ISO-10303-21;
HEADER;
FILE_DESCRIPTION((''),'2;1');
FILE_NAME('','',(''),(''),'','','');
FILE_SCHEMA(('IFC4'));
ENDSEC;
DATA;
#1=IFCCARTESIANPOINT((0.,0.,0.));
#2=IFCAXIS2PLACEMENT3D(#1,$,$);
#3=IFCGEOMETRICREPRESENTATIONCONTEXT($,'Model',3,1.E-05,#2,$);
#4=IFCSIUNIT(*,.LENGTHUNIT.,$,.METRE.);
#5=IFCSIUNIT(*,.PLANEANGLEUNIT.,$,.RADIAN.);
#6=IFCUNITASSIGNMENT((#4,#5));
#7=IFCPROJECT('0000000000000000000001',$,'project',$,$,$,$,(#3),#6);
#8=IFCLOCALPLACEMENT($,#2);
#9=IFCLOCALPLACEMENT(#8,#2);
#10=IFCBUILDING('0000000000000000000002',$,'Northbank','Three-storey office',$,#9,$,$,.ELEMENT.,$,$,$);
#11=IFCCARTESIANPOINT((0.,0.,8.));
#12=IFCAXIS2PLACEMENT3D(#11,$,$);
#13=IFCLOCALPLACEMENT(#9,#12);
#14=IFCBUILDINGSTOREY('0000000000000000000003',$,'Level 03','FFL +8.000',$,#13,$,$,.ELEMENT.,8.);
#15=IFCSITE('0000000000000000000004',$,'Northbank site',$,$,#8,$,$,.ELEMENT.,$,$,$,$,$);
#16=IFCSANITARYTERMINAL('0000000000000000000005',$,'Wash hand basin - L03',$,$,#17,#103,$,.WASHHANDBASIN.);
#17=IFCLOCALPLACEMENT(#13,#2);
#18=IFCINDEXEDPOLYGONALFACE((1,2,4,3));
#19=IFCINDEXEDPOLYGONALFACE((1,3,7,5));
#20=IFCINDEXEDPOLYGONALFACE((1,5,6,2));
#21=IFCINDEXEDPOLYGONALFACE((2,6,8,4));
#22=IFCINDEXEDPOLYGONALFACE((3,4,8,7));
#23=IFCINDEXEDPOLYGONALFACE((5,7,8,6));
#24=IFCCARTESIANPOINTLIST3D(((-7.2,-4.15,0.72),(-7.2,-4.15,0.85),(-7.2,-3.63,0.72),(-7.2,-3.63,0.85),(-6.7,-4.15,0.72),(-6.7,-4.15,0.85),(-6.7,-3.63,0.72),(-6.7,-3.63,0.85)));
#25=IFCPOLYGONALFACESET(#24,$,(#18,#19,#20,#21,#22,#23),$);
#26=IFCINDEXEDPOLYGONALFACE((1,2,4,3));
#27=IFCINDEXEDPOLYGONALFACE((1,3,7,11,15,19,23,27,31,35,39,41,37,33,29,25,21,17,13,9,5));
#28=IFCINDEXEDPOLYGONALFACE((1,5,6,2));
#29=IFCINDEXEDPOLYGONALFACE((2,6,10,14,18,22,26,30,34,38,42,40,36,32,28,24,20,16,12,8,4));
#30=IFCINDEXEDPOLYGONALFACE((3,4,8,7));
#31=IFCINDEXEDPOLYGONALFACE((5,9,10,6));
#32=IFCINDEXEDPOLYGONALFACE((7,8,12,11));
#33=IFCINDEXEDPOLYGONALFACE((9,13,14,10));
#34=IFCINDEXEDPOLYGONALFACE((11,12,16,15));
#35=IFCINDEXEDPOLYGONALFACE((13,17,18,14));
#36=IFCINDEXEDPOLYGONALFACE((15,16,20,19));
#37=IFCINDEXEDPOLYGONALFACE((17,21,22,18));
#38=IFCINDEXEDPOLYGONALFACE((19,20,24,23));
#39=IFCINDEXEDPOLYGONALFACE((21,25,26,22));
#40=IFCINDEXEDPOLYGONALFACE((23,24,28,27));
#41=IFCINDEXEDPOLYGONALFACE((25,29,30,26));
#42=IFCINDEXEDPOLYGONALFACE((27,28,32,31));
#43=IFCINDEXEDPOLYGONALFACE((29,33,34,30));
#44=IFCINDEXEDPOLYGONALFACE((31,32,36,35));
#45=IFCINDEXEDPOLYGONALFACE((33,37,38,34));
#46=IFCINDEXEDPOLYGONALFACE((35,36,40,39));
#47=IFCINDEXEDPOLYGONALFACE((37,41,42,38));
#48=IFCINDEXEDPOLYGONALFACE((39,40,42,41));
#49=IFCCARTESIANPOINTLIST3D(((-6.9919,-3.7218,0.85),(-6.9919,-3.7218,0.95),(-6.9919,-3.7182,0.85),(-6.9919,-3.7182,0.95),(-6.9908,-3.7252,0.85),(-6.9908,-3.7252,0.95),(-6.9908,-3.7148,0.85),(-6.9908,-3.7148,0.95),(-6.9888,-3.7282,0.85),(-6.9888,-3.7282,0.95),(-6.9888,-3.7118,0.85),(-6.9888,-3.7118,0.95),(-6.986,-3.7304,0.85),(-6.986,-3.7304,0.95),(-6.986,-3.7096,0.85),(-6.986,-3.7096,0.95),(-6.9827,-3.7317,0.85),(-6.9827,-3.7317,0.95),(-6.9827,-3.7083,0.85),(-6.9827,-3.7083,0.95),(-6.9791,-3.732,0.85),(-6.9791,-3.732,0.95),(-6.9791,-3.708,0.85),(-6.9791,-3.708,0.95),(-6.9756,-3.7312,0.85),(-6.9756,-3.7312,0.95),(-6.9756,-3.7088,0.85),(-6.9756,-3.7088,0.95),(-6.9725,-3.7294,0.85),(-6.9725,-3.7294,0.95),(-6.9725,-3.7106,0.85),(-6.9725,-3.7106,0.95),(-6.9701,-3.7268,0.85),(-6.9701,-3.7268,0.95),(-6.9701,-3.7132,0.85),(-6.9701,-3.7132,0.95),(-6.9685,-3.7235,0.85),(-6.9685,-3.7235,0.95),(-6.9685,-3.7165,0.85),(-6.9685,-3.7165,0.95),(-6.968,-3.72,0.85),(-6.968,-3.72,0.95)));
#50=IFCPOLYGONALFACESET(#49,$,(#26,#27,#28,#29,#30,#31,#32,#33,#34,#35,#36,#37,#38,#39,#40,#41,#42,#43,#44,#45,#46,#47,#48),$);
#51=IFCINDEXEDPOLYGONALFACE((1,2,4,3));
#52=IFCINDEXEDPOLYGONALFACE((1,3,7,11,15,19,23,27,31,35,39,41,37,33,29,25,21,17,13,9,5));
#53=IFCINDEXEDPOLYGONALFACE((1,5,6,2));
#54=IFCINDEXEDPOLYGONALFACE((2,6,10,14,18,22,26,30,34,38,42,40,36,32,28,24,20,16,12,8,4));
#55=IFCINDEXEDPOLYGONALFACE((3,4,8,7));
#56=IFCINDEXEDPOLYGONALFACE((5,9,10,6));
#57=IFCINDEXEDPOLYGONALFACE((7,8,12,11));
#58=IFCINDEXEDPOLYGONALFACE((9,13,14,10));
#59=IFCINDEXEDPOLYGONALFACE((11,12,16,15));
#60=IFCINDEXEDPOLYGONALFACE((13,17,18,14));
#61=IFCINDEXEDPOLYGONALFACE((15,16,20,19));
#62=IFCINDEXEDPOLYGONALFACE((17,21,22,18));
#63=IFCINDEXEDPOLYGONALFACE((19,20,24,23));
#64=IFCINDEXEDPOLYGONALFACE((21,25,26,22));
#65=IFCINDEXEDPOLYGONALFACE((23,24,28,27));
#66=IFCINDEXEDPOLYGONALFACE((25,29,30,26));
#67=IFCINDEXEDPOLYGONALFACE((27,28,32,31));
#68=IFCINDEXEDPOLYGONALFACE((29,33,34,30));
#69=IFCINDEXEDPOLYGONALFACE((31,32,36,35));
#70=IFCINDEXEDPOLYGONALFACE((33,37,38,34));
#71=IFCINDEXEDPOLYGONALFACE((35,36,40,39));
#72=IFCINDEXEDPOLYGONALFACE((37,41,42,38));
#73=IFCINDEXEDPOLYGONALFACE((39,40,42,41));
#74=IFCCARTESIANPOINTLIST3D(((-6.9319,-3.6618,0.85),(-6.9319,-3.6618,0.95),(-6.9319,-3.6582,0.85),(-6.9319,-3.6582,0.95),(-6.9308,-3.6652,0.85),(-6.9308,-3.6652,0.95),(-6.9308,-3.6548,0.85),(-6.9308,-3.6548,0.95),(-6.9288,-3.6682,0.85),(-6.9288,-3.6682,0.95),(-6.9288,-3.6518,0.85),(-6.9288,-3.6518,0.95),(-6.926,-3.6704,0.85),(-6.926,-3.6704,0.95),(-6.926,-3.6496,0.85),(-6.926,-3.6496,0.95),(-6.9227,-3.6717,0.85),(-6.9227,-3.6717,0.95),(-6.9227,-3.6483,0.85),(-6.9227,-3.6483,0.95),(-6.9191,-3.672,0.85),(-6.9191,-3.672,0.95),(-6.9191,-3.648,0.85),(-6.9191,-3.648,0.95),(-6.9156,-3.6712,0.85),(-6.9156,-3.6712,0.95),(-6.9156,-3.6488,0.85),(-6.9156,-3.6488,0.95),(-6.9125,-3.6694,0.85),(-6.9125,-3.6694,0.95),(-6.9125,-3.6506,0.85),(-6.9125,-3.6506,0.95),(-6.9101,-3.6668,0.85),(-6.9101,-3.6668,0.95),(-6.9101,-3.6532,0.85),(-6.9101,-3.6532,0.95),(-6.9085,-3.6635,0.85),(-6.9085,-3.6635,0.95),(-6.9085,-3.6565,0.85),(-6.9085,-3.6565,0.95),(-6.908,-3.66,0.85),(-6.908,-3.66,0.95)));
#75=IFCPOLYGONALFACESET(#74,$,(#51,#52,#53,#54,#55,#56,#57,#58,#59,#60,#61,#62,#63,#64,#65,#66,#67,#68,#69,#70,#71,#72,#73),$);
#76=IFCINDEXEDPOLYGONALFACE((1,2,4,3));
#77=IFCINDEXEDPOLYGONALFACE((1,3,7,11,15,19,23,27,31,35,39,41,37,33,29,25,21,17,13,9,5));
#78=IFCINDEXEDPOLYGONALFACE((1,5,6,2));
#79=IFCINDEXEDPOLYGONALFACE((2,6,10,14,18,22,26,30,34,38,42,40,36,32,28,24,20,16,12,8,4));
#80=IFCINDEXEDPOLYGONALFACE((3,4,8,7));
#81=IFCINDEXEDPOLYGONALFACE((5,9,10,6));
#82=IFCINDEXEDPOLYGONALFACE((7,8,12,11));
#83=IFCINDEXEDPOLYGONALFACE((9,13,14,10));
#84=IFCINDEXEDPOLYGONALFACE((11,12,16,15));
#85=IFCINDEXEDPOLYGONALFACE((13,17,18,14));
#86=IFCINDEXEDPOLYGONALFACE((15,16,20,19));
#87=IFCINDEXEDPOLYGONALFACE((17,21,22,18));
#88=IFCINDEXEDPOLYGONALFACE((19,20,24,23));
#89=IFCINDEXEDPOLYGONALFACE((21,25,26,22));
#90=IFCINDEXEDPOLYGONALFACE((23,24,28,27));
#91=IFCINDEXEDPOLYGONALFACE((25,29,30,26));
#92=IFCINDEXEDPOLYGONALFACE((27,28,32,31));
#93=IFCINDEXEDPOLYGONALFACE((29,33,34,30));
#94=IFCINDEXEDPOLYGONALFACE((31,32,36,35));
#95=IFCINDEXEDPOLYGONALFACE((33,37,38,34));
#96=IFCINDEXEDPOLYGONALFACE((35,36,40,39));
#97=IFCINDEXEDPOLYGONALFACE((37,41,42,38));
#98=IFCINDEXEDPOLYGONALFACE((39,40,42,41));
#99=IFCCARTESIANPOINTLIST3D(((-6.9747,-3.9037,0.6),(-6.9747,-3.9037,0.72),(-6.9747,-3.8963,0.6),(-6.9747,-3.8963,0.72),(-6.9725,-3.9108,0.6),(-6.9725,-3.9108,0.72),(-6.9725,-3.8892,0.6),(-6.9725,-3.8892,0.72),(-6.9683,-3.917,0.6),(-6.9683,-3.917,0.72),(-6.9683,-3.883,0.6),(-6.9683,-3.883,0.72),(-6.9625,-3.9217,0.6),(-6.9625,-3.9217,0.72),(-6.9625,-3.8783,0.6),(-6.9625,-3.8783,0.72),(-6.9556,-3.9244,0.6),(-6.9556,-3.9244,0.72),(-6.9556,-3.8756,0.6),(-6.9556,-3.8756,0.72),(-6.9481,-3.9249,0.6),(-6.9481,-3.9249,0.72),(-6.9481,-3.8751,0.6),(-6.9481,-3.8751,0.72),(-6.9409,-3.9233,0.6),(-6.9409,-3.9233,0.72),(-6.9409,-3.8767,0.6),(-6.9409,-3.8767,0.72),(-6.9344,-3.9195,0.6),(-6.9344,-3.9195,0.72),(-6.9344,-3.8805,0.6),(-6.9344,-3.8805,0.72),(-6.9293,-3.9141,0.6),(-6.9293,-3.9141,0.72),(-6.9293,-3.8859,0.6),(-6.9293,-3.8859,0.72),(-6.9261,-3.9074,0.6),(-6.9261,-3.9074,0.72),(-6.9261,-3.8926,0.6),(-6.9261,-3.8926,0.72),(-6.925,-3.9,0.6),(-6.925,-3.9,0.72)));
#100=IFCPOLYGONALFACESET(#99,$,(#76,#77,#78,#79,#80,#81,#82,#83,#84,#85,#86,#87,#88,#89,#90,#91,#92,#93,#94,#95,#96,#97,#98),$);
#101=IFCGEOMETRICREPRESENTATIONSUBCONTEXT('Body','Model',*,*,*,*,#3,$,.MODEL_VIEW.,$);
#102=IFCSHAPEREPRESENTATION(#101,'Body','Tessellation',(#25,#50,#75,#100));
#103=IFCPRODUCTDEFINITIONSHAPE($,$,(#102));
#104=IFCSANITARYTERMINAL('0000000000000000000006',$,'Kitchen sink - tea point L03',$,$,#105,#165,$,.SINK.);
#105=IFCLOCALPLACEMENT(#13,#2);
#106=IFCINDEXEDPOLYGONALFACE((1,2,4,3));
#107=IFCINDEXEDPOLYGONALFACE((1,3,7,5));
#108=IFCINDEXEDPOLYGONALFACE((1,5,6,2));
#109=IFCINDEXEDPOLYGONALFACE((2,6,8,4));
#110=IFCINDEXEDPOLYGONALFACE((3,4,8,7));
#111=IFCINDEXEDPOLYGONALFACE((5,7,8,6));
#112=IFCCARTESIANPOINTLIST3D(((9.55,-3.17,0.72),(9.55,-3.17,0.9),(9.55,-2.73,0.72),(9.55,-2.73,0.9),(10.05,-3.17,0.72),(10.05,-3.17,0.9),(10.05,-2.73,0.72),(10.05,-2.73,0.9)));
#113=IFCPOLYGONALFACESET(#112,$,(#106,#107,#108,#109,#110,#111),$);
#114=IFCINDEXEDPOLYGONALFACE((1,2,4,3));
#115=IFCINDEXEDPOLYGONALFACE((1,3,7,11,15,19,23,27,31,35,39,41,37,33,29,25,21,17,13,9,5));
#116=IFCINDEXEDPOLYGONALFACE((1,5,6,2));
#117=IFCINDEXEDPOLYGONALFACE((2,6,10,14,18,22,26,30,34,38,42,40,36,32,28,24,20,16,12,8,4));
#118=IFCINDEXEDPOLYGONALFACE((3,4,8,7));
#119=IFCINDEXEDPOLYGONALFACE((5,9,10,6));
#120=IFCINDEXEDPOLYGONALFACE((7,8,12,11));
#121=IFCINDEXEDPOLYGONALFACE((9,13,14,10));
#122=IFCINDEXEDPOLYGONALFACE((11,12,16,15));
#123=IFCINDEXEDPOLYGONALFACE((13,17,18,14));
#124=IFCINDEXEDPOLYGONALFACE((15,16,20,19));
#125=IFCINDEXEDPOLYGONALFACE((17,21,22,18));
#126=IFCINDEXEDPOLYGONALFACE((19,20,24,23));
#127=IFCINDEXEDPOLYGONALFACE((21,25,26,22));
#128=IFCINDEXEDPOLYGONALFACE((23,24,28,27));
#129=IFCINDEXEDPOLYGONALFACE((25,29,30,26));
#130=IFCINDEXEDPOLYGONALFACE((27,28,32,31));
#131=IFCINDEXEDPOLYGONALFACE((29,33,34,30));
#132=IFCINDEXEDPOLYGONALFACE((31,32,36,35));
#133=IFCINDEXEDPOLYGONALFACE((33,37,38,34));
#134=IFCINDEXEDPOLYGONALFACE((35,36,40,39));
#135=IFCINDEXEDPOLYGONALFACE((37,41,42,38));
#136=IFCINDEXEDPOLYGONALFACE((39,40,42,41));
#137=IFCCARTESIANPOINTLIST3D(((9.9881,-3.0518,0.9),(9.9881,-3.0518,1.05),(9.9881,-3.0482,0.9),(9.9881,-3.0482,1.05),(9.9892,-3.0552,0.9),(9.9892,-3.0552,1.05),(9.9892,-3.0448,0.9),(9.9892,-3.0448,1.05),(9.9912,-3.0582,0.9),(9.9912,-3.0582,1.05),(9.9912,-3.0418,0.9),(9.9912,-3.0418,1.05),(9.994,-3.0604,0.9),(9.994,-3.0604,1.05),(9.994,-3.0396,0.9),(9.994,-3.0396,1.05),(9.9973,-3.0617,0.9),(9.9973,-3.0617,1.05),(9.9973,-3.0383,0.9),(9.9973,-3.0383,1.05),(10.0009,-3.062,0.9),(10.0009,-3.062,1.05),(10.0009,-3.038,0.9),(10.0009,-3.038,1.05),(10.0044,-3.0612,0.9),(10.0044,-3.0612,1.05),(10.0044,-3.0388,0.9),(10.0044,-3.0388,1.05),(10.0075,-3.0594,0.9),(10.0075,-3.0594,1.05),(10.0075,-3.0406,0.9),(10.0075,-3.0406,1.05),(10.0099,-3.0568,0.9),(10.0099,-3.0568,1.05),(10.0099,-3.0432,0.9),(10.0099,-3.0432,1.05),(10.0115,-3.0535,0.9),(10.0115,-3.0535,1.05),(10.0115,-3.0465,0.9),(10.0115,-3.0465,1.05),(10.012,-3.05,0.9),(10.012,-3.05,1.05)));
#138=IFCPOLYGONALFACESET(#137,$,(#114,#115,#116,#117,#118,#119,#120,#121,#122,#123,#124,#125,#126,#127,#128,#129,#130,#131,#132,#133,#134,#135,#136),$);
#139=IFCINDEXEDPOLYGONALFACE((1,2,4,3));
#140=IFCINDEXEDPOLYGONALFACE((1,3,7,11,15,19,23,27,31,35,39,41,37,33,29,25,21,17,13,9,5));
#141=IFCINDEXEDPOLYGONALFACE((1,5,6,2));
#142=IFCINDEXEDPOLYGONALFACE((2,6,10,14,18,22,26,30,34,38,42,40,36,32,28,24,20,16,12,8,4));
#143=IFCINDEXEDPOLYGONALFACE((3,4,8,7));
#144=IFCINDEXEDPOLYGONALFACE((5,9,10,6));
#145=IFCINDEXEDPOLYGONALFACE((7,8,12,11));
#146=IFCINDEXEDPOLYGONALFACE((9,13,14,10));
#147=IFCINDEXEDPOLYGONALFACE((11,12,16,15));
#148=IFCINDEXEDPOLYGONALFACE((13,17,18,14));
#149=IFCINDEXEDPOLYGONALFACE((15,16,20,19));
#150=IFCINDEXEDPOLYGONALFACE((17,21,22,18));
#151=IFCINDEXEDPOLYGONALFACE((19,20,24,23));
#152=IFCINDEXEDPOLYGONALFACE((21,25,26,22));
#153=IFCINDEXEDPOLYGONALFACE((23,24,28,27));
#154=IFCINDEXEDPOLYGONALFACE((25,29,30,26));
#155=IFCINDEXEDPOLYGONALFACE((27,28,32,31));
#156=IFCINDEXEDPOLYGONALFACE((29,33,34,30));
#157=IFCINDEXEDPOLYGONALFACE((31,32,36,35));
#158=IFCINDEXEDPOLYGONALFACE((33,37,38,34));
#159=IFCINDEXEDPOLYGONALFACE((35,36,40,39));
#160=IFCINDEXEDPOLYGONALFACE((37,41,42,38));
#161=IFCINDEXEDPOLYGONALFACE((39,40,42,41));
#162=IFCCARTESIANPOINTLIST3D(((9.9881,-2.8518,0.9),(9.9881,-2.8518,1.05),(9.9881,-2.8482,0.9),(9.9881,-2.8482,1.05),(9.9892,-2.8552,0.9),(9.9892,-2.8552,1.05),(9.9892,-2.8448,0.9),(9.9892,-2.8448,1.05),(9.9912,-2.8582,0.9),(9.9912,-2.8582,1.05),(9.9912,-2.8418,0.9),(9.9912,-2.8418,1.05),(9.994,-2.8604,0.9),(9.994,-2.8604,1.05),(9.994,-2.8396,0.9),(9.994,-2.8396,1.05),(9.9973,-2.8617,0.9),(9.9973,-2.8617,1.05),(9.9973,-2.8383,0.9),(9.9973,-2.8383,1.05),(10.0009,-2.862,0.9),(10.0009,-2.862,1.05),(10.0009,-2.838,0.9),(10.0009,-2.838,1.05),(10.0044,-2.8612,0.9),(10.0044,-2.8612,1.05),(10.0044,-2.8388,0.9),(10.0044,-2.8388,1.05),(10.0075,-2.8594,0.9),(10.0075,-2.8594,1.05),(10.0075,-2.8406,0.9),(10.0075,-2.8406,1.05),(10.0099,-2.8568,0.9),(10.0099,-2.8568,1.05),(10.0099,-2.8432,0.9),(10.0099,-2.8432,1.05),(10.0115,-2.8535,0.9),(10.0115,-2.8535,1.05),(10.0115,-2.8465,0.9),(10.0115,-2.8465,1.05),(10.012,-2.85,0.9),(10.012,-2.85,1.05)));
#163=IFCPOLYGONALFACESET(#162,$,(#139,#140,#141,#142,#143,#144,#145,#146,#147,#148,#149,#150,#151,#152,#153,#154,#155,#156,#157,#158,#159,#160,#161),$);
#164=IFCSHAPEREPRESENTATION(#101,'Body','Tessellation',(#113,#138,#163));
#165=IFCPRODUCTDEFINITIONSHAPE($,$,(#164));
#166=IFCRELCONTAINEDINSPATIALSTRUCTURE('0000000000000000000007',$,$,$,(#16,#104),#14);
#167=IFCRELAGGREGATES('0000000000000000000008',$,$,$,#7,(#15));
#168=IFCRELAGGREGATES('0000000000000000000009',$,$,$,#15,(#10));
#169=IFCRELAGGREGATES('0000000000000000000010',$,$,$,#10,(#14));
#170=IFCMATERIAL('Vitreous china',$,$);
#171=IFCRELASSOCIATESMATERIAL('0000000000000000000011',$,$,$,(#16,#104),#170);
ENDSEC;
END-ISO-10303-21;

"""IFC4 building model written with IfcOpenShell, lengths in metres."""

from ifc_helpers import new_model, si_unit, frame, origin, place, context, subcontext, project, spatial, rectangle, circle, extrude, material, element, save


model = new_model("IFC4")

# Units and contexts
model_context = context("Model", 3, precision=1e-05, world=origin())
body_context = subcontext(model_context, "Body", "Model", "MODEL_VIEW")
ifc_project = project(units=[si_unit("LENGTHUNIT", "METRE"), si_unit("PLANEANGLEUNIT", "RADIAN")], contexts=[model_context])

# Site, building, storey
site_placement = place(None, origin())
site = spatial("IfcSite", under=ifc_project, at=site_placement, Name="Northbank site", CompositionType="ELEMENT")
building_placement = place(site_placement, origin())
building = spatial("IfcBuilding", under=site, at=building_placement, Name="Northbank", Description="Three-storey office", CompositionType="ELEMENT")
storey_placement = place(building_placement, frame((0.0, 0.0, 8.0)))
storey = spatial("IfcBuildingStorey", under=building, at=storey_placement, Name="Level 03", Description="FFL +8.000", CompositionType="ELEMENT", Elevation=8.0)

# Sanitary terminals
ifc_material_1 = material(Name="Vitreous china")
sanitary_terminal_1_placement = place(storey_placement, frame((0.0, 0.0, -8.0)))
element("IfcSanitaryTerminal", 1, at=sanitary_terminal_1_placement, inside=storey, material=ifc_material_1, Name="Wash hand basin - L03", PredefinedType="WASHHANDBASIN", context=body_context, shape_type="SweptSolid", body=[
    extrude(rectangle(XDim=0.5, YDim=0.52), frame((-6.95, -3.89, 8.72)), (0.0, 0.0, 1.0), 0.13),
    extrude(circle(Radius=0.012), frame((-6.98, -3.72, 8.85), z_axis=(0.0, 0.0, 1.0), x_axis=(1.0, 0.0, 0.0)), (0.0, 0.0, 1.0), 0.1),
    extrude(circle(Radius=0.012), frame((-6.92, -3.66, 8.85), z_axis=(0.0, 0.0, 1.0), x_axis=(1.0, 0.0, 0.0)), (0.0, 0.0, 1.0), 0.1),
    extrude(circle(Radius=0.025), frame((-6.95, -3.9, 8.72), z_axis=(0.0, 0.0, -1.0), x_axis=(1.0, 0.0, 0.0)), (0.0, 0.0, 1.0), 0.12),
])
sanitary_terminal_2_placement = place(storey_placement, frame((0.0, 0.0, -8.0)))
element("IfcSanitaryTerminal", 2, at=sanitary_terminal_2_placement, inside=storey, material=ifc_material_1, Name="Kitchen sink - tea point L03", PredefinedType="SINK", context=body_context, shape_type="SweptSolid", body=[
    extrude(rectangle(XDim=0.5, YDim=0.44), frame((9.8, -2.95, 8.72)), (0.0, 0.0, 1.0), 0.18),
    extrude(circle(Radius=0.012), frame((10.0, -3.05, 8.9), z_axis=(0.0, 0.0, 1.0), x_axis=(1.0, 0.0, 0.0)), (0.0, 0.0, 1.0), 0.15),
    extrude(circle(Radius=0.012), frame((10.0, -2.85, 8.9), z_axis=(0.0, 0.0, 1.0), x_axis=(1.0, 0.0, 0.0)), (0.0, 0.0, 1.0), 0.15),
])

save(model, "model.ifc")
